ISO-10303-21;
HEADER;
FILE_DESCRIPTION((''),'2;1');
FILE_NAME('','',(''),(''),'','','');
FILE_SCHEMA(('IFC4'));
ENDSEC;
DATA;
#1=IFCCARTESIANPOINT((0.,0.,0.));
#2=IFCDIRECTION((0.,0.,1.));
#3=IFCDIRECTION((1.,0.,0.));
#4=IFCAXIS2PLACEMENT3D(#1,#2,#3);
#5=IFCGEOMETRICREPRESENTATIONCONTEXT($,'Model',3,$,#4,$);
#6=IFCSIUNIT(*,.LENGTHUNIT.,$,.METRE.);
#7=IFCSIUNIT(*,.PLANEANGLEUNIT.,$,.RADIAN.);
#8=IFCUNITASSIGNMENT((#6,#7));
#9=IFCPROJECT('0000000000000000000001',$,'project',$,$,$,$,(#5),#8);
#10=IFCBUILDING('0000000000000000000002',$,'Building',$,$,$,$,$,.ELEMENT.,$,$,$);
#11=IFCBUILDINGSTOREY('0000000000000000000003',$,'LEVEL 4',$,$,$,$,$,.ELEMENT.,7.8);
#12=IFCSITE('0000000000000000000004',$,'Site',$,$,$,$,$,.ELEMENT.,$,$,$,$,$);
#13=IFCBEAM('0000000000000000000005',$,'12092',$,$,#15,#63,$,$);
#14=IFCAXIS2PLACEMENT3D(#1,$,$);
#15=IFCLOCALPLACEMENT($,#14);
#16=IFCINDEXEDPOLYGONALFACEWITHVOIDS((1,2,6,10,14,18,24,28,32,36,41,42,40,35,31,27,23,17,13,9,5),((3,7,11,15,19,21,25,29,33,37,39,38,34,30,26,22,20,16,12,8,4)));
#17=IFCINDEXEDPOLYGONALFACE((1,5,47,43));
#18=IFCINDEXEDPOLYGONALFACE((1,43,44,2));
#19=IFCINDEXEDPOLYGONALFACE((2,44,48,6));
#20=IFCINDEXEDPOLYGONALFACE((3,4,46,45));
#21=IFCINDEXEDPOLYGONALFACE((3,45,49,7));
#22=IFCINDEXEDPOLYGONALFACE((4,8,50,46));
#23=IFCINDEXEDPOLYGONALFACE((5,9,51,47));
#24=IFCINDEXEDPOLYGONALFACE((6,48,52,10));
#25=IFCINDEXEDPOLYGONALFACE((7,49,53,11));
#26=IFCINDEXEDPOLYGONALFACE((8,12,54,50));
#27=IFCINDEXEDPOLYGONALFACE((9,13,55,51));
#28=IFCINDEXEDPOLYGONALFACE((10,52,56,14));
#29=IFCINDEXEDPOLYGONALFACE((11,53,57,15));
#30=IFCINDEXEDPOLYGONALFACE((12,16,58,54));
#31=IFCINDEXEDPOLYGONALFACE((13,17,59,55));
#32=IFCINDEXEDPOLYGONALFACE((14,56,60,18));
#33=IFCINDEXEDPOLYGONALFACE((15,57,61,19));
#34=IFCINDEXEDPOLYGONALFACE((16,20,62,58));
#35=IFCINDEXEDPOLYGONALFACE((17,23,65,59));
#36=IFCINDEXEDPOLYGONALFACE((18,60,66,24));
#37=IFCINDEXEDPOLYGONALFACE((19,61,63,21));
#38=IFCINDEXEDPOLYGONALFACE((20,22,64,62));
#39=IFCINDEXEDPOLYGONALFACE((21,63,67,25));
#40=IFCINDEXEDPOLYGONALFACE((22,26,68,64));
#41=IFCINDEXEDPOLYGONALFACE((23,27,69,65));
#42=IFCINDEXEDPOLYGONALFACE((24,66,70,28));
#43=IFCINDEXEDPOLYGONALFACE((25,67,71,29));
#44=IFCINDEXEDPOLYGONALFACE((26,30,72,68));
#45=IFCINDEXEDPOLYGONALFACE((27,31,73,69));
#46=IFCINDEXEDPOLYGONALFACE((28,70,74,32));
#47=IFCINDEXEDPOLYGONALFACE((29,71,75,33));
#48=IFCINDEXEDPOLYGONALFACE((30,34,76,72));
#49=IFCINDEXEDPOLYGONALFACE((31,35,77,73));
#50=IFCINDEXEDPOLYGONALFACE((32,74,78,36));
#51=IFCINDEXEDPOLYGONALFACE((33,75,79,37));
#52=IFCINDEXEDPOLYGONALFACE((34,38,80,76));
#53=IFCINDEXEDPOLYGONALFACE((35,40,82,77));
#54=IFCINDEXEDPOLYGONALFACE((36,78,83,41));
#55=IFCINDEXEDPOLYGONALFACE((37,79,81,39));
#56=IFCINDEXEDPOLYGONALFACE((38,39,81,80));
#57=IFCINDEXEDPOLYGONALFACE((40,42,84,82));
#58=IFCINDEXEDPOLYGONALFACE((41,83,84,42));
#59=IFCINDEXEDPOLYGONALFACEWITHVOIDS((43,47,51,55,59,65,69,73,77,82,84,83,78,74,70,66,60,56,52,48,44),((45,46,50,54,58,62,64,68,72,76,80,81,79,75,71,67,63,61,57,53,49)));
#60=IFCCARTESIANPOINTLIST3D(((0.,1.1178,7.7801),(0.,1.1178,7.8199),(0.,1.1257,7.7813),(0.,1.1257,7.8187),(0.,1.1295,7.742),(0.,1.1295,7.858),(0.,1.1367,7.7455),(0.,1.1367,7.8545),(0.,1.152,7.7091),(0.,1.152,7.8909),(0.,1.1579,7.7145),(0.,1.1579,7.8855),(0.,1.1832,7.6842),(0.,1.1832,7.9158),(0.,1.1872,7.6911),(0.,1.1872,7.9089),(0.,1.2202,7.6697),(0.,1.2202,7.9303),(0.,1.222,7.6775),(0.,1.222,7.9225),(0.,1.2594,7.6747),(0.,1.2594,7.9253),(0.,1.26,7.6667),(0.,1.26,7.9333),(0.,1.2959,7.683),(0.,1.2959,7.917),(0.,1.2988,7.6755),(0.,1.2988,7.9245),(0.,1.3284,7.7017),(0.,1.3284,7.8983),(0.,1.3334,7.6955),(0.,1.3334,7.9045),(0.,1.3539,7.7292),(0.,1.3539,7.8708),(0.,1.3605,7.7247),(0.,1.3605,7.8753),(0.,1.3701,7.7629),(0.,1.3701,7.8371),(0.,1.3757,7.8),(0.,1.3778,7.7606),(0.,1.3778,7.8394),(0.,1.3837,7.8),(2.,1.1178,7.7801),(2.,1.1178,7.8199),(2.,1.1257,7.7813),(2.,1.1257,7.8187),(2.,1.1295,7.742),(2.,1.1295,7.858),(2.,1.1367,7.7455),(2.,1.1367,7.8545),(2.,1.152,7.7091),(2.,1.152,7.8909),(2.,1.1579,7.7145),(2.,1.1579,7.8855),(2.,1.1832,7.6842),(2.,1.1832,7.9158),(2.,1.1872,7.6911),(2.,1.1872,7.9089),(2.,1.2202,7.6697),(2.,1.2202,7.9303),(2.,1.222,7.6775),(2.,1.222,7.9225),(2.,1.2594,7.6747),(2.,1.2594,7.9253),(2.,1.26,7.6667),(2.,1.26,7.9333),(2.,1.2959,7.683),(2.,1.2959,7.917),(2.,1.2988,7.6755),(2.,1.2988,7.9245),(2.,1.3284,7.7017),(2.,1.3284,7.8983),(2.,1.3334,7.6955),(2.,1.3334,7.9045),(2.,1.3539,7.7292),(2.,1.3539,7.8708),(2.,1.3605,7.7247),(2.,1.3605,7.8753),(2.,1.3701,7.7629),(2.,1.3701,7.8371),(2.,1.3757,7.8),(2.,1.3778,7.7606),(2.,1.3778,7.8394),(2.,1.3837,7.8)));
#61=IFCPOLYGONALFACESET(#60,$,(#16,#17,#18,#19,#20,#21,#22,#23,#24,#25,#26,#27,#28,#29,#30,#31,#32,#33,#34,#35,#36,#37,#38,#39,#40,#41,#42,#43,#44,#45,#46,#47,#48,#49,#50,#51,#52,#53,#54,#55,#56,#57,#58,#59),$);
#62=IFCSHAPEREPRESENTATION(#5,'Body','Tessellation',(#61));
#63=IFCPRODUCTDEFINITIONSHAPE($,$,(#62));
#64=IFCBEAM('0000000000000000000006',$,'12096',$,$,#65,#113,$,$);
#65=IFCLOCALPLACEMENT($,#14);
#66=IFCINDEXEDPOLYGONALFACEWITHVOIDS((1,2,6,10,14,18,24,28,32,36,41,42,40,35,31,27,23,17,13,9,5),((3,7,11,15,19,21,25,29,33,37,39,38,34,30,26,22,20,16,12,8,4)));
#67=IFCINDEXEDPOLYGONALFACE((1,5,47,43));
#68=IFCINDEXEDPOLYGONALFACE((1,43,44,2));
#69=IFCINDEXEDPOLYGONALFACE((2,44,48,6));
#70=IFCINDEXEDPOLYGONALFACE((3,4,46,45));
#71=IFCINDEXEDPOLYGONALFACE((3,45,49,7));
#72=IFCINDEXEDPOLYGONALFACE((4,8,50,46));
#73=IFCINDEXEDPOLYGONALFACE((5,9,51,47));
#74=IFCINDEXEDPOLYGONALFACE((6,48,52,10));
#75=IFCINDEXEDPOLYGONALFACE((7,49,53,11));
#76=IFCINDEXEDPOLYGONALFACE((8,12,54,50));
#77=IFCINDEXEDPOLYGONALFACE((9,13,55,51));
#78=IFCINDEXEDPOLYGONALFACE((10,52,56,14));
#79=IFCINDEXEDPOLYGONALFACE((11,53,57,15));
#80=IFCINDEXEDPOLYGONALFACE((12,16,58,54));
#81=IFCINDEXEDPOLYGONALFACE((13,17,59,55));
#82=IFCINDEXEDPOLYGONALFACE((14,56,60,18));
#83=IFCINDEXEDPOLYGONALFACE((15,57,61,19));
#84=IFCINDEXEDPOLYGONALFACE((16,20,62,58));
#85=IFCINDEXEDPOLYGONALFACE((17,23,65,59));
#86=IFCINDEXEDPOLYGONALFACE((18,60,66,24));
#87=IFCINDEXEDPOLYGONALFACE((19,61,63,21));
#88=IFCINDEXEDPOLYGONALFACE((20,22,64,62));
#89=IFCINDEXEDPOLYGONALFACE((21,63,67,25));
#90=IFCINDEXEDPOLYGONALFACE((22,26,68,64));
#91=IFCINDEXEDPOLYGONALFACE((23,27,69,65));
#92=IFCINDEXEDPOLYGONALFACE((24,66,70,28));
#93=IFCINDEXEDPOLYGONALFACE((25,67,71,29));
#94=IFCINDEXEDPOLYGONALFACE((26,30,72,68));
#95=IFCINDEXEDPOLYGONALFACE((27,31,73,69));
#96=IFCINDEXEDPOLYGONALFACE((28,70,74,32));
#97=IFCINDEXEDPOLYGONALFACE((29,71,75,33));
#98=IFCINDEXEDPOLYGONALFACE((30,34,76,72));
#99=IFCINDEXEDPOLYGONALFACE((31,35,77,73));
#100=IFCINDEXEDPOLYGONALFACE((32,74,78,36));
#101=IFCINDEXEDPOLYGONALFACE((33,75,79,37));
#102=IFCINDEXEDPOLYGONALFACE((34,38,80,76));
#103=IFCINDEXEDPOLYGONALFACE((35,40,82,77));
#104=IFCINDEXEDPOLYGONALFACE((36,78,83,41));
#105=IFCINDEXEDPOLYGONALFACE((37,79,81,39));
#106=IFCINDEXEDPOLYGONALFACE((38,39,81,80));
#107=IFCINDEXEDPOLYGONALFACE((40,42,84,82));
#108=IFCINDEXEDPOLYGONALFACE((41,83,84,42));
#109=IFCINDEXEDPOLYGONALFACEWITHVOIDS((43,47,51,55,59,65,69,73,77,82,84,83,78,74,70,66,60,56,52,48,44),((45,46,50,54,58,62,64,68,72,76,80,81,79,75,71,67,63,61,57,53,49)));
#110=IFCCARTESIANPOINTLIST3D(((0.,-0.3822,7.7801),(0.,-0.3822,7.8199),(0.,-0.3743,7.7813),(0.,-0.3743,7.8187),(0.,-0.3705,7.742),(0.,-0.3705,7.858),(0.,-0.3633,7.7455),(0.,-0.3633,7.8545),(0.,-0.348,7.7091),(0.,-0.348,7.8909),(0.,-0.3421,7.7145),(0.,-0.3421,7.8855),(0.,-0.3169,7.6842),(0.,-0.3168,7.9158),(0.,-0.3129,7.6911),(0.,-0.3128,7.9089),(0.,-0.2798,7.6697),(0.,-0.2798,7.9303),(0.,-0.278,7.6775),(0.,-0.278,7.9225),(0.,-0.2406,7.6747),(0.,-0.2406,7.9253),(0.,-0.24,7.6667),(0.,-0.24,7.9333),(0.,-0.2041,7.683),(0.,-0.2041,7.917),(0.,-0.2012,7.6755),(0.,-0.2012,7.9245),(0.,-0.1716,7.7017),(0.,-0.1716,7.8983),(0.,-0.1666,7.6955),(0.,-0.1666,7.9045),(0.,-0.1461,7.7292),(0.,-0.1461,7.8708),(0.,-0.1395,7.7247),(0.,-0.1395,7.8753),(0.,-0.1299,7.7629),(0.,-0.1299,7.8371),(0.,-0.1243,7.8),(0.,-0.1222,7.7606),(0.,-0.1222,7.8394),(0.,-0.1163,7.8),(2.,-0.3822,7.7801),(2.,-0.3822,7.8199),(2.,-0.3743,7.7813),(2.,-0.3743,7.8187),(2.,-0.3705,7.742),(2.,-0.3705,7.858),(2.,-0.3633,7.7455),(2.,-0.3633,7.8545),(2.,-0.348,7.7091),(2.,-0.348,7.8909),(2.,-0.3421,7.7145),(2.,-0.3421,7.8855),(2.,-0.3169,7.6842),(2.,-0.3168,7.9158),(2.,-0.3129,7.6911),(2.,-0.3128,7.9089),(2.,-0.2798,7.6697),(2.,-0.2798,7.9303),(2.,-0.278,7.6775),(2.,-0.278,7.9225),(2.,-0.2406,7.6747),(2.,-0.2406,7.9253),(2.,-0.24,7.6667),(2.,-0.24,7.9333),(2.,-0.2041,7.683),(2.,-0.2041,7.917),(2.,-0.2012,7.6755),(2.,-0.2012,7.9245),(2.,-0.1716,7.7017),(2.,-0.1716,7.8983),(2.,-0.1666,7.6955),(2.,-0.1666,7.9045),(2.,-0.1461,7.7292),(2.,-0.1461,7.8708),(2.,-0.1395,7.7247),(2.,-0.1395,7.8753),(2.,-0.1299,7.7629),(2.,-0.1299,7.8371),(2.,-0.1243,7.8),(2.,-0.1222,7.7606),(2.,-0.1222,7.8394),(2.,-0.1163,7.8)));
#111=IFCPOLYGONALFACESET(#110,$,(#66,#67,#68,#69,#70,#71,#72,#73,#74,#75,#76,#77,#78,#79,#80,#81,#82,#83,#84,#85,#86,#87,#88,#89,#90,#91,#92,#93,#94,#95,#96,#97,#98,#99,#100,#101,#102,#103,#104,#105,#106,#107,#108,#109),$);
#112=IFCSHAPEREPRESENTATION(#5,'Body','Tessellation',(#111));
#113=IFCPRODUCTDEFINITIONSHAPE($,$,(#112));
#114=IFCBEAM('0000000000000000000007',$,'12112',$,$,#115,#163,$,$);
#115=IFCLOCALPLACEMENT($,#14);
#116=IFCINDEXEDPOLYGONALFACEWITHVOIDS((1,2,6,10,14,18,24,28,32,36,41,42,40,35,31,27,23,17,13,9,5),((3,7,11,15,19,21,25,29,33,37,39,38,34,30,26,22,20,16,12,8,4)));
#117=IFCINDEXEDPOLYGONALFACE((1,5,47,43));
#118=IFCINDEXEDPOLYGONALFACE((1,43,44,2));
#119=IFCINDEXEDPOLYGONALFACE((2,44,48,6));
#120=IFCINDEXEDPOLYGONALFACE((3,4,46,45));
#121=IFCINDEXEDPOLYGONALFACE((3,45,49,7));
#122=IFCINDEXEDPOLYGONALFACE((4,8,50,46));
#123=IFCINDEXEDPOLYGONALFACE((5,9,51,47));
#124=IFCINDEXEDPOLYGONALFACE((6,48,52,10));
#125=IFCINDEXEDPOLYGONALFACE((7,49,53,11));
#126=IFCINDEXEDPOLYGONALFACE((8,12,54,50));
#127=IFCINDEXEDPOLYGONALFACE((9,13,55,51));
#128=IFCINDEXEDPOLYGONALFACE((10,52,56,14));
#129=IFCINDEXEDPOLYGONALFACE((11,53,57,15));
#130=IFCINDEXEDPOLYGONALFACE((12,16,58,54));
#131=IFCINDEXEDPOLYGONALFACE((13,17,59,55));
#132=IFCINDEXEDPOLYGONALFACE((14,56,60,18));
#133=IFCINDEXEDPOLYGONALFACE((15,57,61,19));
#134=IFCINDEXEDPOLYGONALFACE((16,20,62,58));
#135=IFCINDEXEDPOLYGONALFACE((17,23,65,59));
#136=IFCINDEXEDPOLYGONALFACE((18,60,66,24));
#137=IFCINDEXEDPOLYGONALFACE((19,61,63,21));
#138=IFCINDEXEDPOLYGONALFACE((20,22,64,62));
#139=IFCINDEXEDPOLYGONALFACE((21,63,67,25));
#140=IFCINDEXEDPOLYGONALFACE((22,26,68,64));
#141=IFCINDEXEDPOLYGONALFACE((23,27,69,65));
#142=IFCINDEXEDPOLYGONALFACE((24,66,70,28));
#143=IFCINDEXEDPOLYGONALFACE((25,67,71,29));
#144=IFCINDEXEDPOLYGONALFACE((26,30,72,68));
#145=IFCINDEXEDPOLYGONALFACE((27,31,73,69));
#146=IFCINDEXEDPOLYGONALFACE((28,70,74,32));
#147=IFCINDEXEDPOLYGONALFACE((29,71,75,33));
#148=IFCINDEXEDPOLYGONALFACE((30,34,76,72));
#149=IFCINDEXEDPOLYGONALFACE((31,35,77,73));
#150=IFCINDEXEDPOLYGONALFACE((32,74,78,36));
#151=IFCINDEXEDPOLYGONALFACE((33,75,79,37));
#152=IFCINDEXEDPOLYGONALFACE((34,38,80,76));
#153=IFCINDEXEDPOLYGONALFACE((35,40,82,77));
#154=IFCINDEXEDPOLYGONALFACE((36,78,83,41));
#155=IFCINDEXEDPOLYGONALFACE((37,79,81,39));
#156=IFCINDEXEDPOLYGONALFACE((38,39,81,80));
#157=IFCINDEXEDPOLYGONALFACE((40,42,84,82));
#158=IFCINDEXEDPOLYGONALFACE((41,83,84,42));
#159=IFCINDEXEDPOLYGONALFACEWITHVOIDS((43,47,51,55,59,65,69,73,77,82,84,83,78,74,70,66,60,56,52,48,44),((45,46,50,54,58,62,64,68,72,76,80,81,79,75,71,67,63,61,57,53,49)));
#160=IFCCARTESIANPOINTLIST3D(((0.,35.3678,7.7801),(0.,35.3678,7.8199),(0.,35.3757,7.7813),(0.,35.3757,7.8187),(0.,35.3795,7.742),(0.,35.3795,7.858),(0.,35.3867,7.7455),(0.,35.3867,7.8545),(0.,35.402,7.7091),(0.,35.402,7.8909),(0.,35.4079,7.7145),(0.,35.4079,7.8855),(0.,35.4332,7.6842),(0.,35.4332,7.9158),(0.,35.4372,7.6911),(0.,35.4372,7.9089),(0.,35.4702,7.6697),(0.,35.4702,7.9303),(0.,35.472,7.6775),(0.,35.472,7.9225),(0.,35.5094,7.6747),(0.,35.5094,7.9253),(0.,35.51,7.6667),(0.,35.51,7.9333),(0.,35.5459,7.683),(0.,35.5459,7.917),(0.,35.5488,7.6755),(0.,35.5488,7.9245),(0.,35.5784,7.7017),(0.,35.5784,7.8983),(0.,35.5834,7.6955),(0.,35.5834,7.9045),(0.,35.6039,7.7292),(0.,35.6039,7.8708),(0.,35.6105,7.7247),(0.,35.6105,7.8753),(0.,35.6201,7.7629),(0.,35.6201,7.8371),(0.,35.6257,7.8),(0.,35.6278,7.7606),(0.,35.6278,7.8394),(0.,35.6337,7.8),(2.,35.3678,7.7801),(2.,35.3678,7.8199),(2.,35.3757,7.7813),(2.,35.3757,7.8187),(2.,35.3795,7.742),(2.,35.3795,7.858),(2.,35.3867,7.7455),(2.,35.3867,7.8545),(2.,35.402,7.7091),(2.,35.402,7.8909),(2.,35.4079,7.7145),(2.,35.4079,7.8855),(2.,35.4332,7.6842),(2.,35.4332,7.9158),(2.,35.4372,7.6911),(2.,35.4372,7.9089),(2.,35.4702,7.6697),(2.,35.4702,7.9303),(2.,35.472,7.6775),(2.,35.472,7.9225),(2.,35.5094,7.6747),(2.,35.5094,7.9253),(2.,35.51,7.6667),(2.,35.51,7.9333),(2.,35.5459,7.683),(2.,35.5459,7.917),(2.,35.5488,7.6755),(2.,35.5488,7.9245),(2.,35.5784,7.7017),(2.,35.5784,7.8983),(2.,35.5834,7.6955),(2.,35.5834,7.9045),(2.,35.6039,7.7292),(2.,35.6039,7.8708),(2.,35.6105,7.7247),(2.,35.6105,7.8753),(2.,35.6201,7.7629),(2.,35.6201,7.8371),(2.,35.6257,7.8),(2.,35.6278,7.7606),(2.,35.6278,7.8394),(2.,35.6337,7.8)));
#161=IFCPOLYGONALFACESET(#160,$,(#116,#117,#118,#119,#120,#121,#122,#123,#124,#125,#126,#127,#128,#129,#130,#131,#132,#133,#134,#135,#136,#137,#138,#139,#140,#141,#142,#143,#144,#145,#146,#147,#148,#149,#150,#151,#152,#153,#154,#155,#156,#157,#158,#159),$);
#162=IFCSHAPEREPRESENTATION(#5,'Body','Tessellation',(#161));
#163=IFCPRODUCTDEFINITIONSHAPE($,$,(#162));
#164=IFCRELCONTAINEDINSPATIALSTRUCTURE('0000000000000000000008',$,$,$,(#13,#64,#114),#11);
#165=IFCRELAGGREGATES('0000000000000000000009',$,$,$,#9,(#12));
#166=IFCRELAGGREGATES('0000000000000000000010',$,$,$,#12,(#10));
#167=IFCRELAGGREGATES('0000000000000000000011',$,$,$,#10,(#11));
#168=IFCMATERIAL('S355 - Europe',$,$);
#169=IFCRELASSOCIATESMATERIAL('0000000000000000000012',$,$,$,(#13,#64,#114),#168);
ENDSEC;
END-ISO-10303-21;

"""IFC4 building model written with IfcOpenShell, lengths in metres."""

from ifc_helpers import new_model, si_unit, frame, origin_with_axes, origin_2d_with_axis, place, context, project, spatial, hollow_circle, extrude, material, material_profile, profile_set, profile_usage, element, save


model = new_model("IFC4")

# Units and contexts
model_context = context("Model", 3, world=origin_with_axes())
ifc_project = project(units=[si_unit("LENGTHUNIT", "METRE"), si_unit("PLANEANGLEUNIT", "RADIAN")], contexts=[model_context])

# Site, building, storey
site = spatial("IfcSite", under=ifc_project, Name="Site", CompositionType="ELEMENT")
building = spatial("IfcBuilding", under=site, Name="Building", CompositionType="ELEMENT")
storey = spatial("IfcBuildingStorey", under=building, Name="LEVEL 4", CompositionType="ELEMENT", Elevation=7.8)

# Shared definitions
ifc_material = material(Name="S355 - Europe")

# Beams
ifc_material_profile_1 = material_profile(ifc_material, hollow_circle(Radius=0.1337, WallThickness=0.008, at=origin_2d_with_axis()))
ifc_profile_set_1 = profile_set([ifc_material_profile_1])
ifc_profile_usage_1 = profile_usage(ifc_profile_set_1, cardinal=10)
beam_1_placement = place(None, frame((0.0, 1.25, 7.8), z_axis=(1.0, 0.0, 0.0), x_axis=(0.0, 1.0, 0.0)))
element("IfcBeam", 1, at=beam_1_placement, inside=storey, material=ifc_profile_usage_1, Name="12092", context=model_context, shape_type="SweptSolid", body=[
    extrude(hollow_circle(Radius=0.1337, WallThickness=0.008, at=origin_2d_with_axis()), origin_with_axes(), (0.0, 0.0, 1.0), 2.0),
])
ifc_material_profile_2 = material_profile(ifc_material, hollow_circle(Radius=0.1337, WallThickness=0.008, at=origin_2d_with_axis()))
ifc_profile_set_2 = profile_set([ifc_material_profile_2])
ifc_profile_usage_2 = profile_usage(ifc_profile_set_2, cardinal=10)
beam_2_placement = place(None, frame((0.0, -0.25, 7.8), z_axis=(1.0, 0.0, 0.0), x_axis=(0.0, 1.0, 0.0)))
element("IfcBeam", 2, at=beam_2_placement, inside=storey, material=ifc_profile_usage_2, Name="12096", context=model_context, shape_type="SweptSolid", body=[
    extrude(hollow_circle(Radius=0.1337, WallThickness=0.008, at=origin_2d_with_axis()), origin_with_axes(), (0.0, 0.0, 1.0), 2.0),
])
ifc_material_profile_3 = material_profile(ifc_material, hollow_circle(Radius=0.1337, WallThickness=0.008, at=origin_2d_with_axis()))
ifc_profile_set_3 = profile_set([ifc_material_profile_3])
ifc_profile_usage_3 = profile_usage(ifc_profile_set_3, cardinal=10)
beam_3_placement = place(None, frame((0.0, 35.5, 7.8), z_axis=(1.0, 0.0, 0.0), x_axis=(0.0, 1.0, 0.0)))
element("IfcBeam", 3, at=beam_3_placement, inside=storey, material=ifc_profile_usage_3, Name="12112", context=model_context, shape_type="SweptSolid", body=[
    extrude(hollow_circle(Radius=0.1337, WallThickness=0.008, at=origin_2d_with_axis()), origin_with_axes(), (0.0, 0.0, 1.0), 2.0),
])

save(model, "model.ifc")
